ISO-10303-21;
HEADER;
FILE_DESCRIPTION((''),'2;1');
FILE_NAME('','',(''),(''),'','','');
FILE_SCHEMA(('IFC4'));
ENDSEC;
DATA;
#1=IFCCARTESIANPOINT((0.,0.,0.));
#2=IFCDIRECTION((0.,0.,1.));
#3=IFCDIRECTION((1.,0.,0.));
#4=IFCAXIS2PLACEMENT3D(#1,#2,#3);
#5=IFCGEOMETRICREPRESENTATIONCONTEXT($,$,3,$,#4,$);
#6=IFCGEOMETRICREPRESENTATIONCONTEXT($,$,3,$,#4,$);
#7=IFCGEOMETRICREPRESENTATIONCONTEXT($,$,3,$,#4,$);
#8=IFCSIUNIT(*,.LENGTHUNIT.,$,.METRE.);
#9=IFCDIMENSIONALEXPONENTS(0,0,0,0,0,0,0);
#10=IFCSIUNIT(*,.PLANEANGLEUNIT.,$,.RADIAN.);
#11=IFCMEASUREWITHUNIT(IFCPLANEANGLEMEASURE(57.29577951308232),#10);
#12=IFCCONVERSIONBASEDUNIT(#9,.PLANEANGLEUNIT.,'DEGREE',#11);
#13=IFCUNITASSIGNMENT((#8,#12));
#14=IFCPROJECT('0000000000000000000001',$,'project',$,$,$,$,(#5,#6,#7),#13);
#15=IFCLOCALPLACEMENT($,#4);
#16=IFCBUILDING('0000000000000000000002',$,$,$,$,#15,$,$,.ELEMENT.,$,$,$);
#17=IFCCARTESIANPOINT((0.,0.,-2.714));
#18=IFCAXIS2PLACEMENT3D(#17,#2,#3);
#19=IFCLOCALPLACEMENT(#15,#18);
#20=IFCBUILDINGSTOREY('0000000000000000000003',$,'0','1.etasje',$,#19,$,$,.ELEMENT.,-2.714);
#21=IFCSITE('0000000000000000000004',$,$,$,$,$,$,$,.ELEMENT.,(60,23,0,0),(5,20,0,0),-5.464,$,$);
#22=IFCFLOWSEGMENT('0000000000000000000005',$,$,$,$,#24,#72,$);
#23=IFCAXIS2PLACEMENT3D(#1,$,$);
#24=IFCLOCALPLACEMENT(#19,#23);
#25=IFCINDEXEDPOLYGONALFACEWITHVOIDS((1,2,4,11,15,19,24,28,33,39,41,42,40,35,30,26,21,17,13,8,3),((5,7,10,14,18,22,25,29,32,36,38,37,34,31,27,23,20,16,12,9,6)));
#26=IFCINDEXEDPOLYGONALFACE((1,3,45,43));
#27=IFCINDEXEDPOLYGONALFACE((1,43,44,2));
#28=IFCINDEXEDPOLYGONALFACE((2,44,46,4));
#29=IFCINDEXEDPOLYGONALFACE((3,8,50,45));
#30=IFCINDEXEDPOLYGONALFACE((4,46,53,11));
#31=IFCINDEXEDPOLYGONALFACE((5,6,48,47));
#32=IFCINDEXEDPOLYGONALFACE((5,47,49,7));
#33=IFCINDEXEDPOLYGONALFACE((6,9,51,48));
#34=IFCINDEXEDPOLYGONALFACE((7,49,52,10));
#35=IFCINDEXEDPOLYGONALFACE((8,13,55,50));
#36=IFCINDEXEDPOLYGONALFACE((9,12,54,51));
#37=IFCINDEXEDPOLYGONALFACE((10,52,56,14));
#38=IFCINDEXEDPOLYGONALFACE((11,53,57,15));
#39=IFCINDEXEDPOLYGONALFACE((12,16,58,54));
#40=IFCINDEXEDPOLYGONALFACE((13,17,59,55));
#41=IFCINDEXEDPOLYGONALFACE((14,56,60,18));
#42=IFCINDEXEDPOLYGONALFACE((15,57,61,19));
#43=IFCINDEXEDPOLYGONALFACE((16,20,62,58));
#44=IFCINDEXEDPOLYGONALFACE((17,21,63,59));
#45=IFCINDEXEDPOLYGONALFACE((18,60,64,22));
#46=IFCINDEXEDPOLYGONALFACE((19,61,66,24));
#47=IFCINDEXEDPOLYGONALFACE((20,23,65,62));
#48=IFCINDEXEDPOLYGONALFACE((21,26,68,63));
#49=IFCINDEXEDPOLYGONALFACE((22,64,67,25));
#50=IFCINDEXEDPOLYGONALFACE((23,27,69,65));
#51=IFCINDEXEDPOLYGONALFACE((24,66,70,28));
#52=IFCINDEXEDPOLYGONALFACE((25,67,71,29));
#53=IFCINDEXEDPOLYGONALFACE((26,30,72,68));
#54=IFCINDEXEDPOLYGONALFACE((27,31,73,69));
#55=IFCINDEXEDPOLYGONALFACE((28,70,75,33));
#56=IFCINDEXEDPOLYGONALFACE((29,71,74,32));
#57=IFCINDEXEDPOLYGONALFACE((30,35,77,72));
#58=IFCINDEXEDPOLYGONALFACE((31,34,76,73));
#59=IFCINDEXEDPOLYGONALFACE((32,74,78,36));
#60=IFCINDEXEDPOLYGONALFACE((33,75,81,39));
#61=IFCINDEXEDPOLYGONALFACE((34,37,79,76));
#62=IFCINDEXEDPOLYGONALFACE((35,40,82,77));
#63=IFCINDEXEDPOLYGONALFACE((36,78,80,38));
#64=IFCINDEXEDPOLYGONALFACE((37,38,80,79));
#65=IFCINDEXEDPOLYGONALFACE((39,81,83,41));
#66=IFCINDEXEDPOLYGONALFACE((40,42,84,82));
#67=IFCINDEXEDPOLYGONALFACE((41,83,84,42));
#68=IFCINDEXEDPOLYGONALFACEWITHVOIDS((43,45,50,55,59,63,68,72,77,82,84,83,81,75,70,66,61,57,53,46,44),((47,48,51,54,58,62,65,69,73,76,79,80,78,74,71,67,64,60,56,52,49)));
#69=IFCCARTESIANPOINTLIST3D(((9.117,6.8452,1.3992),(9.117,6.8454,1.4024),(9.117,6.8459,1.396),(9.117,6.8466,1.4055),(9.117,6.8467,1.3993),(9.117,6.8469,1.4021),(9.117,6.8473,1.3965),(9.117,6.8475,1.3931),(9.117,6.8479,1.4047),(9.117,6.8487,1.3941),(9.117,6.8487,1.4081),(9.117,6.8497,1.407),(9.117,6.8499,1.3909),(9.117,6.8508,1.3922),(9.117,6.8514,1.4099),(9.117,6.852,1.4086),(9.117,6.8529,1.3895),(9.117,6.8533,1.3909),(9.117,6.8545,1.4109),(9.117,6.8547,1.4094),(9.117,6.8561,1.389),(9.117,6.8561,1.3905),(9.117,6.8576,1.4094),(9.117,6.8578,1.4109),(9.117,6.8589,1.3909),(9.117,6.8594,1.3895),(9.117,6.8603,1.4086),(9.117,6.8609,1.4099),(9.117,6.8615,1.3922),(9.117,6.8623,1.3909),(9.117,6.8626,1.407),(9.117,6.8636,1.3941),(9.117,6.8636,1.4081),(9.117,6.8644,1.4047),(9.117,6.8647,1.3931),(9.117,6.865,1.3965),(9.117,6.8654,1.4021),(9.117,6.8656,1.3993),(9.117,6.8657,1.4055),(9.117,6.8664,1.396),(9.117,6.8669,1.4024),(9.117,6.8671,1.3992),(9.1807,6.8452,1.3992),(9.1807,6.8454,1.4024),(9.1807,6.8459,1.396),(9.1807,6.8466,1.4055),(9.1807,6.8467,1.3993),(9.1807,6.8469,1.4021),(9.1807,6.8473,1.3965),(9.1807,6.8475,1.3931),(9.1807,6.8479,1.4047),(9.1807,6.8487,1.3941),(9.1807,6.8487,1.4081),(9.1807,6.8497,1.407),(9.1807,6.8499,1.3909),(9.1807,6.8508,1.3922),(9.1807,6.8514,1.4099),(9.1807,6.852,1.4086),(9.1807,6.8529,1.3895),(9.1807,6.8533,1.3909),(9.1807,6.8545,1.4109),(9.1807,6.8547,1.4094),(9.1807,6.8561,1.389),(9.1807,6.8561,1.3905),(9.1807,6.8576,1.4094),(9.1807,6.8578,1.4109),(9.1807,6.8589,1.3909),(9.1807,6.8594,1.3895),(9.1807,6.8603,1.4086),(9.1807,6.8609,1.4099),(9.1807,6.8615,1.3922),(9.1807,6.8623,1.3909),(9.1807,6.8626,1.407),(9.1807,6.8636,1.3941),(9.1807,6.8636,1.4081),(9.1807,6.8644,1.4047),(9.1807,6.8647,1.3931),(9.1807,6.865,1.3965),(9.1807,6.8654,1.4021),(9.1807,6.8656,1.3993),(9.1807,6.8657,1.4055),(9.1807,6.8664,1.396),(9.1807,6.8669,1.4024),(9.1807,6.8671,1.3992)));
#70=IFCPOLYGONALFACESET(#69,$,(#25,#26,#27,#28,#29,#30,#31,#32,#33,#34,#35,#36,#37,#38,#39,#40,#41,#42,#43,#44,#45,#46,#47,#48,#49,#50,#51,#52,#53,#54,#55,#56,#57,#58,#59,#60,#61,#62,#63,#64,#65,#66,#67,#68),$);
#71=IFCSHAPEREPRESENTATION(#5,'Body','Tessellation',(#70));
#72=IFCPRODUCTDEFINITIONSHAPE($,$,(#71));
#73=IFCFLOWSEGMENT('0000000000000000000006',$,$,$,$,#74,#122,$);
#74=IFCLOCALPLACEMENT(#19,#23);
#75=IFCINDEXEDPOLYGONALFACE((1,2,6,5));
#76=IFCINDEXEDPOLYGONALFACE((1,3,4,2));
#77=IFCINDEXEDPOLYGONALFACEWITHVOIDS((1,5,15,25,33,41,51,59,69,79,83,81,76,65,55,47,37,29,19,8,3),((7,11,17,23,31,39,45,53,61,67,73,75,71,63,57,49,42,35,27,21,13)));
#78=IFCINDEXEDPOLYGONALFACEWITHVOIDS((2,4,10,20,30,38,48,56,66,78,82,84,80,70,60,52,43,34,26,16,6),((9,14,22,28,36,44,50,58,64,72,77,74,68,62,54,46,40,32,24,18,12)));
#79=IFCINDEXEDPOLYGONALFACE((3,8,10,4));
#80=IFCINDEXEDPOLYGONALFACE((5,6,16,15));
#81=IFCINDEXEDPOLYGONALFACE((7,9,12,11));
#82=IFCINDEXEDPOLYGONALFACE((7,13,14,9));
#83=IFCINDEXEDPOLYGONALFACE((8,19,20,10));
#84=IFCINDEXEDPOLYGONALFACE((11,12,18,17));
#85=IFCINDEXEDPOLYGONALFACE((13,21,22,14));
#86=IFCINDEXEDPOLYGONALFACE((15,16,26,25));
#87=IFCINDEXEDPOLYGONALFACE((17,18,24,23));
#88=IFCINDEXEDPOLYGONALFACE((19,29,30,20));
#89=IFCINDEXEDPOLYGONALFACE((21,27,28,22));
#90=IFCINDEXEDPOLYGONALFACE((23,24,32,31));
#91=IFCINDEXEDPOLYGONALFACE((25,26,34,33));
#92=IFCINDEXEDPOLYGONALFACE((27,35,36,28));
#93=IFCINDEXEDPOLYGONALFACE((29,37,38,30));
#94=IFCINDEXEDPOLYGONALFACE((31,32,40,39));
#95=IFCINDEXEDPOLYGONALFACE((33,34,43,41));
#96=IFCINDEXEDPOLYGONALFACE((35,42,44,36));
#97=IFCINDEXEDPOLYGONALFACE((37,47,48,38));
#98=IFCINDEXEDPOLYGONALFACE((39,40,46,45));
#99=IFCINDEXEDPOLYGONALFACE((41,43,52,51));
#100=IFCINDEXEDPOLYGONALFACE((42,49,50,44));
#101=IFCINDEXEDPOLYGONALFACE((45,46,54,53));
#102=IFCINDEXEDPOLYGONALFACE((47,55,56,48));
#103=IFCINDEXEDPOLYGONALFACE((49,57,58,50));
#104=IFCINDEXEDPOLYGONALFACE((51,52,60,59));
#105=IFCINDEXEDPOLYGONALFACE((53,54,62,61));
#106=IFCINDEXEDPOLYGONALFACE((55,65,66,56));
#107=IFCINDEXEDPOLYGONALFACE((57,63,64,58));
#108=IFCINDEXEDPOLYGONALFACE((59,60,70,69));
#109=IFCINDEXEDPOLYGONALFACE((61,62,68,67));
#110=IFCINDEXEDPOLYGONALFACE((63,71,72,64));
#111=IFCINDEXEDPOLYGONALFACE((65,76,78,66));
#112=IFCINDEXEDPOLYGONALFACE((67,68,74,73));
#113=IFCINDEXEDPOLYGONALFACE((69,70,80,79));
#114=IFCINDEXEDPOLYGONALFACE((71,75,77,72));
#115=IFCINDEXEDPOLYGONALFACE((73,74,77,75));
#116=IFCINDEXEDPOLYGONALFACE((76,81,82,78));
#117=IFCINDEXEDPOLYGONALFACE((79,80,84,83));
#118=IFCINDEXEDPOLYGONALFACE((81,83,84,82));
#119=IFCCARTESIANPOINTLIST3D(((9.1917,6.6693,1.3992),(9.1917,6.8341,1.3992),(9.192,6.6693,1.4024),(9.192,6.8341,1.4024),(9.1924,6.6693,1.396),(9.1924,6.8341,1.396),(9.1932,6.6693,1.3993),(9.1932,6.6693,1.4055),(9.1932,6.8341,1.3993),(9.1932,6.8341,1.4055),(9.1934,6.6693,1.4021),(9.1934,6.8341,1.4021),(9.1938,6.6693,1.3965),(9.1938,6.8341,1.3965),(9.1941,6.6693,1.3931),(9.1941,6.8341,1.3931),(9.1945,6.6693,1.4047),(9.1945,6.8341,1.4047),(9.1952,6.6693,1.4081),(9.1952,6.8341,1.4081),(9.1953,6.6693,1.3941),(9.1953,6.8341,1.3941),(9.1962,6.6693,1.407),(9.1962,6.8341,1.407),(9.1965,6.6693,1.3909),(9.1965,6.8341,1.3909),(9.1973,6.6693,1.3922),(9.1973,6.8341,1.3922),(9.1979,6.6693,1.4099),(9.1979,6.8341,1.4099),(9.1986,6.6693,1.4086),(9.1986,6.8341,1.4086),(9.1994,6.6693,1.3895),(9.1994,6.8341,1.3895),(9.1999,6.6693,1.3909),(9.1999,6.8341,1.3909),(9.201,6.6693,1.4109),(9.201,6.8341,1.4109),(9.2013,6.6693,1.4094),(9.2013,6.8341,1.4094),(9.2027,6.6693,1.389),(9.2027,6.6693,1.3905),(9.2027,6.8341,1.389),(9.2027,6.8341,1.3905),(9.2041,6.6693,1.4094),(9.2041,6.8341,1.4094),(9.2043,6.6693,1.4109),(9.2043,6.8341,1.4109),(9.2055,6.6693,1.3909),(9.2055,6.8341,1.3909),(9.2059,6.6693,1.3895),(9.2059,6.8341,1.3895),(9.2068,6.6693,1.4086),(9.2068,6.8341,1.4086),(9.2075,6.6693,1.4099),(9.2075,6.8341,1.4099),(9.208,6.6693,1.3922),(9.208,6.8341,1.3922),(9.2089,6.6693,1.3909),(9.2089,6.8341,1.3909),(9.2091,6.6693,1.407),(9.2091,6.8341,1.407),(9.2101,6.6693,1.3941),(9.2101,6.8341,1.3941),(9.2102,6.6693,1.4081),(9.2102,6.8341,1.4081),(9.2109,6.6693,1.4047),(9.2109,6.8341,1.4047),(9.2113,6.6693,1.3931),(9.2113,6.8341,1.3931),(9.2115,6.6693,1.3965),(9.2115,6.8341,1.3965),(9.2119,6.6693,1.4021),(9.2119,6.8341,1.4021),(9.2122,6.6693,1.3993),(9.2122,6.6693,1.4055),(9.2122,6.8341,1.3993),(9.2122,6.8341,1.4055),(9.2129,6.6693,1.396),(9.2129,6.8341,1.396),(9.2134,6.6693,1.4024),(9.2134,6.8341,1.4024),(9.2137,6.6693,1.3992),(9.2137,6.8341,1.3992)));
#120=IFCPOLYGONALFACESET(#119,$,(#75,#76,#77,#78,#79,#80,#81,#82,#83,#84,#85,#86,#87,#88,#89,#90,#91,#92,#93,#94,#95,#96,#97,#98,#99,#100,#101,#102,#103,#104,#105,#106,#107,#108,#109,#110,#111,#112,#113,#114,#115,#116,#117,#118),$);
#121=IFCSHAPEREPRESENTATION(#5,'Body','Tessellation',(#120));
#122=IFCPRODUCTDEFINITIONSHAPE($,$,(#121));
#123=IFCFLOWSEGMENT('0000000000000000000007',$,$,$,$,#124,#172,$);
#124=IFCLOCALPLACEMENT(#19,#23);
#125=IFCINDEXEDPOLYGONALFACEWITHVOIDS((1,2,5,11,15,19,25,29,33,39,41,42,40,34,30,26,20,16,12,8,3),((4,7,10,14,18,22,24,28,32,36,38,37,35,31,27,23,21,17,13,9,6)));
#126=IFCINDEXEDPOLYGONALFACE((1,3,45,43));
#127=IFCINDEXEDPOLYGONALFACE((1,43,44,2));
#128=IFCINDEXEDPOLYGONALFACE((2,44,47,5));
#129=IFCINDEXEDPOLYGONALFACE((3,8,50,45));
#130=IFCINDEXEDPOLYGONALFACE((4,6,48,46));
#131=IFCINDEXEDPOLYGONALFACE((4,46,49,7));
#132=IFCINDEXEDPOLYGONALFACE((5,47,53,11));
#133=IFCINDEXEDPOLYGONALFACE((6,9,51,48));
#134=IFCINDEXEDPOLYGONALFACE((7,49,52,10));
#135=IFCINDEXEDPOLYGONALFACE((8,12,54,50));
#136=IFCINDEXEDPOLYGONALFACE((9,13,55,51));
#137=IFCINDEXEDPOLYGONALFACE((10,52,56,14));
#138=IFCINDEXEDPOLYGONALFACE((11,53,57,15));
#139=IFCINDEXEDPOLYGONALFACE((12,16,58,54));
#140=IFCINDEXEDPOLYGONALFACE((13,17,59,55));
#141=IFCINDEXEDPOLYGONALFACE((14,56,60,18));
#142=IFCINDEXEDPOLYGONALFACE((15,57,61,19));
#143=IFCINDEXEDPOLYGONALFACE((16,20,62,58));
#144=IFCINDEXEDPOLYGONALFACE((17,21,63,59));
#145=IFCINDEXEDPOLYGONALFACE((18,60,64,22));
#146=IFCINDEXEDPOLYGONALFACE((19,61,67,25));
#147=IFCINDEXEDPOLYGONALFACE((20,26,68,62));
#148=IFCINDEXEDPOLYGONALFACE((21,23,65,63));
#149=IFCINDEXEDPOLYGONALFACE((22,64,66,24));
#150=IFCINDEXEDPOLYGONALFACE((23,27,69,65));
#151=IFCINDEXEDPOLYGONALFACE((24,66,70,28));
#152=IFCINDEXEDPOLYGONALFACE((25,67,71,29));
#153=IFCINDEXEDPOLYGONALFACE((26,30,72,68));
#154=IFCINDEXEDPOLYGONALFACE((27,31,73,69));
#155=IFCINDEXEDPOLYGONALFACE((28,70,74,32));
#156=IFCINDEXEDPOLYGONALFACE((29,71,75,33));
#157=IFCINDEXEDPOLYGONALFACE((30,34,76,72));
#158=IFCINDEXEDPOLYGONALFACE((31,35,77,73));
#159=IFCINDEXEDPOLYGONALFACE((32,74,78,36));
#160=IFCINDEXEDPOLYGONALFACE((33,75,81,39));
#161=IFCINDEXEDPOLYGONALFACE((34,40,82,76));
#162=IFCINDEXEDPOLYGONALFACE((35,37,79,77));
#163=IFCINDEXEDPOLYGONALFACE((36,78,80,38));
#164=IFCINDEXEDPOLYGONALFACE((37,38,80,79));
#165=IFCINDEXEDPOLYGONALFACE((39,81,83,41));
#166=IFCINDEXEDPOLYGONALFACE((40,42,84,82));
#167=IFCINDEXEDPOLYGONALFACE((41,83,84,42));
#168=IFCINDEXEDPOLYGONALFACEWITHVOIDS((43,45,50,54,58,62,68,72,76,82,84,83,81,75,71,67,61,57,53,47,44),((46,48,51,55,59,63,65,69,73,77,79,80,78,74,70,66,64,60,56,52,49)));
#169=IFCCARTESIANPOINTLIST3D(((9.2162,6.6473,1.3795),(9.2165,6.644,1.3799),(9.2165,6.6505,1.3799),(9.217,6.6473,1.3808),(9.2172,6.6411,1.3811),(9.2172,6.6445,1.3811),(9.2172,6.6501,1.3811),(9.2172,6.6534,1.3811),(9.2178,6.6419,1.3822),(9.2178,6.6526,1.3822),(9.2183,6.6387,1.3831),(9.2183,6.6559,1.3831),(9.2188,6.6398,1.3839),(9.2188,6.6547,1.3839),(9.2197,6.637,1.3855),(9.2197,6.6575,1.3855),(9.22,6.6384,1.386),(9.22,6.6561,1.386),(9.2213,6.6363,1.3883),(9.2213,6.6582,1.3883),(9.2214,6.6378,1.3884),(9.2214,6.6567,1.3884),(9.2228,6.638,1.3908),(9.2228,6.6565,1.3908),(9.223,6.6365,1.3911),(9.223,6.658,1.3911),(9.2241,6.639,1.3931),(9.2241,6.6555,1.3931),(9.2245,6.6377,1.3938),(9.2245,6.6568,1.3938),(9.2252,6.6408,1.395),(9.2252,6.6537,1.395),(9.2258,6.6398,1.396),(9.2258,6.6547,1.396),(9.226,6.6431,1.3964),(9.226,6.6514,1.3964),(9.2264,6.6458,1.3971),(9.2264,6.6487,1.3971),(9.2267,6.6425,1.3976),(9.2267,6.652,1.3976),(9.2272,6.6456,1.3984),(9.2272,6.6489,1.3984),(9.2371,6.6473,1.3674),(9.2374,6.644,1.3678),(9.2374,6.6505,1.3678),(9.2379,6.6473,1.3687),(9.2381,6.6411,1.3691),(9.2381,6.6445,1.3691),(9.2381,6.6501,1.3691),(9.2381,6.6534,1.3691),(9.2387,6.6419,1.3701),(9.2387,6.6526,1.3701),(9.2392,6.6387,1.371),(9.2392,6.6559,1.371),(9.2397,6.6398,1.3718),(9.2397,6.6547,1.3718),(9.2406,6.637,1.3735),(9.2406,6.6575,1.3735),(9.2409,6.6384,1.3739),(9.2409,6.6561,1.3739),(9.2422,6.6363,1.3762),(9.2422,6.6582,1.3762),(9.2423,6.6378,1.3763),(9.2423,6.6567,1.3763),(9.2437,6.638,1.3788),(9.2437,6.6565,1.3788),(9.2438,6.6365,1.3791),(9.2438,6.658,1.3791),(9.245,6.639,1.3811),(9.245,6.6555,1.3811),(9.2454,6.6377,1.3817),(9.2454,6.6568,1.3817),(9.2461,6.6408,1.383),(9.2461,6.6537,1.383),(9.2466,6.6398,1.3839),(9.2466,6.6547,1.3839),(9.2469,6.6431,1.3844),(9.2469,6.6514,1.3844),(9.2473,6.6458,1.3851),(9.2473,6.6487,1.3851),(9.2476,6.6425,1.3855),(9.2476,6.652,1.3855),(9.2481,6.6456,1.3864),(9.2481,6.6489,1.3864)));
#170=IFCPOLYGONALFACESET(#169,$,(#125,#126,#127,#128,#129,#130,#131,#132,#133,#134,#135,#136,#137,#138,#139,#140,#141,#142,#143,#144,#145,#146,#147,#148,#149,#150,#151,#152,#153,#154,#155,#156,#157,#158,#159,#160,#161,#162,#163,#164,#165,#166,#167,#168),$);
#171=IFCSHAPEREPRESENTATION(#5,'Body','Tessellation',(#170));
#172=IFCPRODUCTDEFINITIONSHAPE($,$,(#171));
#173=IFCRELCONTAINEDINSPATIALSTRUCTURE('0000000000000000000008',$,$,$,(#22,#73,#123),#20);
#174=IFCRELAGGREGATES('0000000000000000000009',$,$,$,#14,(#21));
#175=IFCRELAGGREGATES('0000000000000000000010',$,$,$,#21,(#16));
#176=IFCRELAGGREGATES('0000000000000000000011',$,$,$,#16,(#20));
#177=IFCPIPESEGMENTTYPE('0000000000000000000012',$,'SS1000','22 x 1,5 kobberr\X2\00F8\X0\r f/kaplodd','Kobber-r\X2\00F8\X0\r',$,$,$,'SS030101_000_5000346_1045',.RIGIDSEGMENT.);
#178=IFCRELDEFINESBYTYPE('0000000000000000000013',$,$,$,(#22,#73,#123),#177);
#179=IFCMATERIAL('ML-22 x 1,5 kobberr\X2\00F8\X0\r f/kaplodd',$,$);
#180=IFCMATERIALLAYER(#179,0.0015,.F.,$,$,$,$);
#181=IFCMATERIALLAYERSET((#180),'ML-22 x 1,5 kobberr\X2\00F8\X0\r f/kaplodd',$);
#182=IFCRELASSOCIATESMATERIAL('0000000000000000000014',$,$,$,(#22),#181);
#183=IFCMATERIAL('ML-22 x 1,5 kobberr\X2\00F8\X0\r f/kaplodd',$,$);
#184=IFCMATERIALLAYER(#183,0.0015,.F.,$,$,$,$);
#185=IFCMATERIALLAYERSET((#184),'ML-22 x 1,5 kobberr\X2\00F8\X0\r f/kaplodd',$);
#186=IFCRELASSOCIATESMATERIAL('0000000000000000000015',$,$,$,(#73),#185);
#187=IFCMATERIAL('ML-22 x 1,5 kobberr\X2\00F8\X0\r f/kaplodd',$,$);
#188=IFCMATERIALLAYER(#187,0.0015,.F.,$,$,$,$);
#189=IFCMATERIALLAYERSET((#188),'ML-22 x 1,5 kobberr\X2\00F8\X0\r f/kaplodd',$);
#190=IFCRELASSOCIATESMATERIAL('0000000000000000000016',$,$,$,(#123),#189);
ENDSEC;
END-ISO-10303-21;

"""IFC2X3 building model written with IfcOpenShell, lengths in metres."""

from ifc_helpers import new_model, entity, si_unit, converted_unit, frame, origin_with_axes, origin_2d_with_axis, place, context, project, spatial, hollow_circle, extrude, material, layer, layer_set, layer_usage, type_object, element, save


model = new_model("IFC2X3")

# Units and contexts
context_of_model_1 = context(None, 3, world=origin_with_axes())
context_of_model_2 = context(None, 3, world=origin_with_axes())
context_of_model_3 = context(None, 3, world=origin_with_axes())
ifc_project = project(units=[si_unit("LENGTHUNIT", "METRE"), converted_unit("PLANEANGLEUNIT", "DEGREE", entity("IfcPlaneAngleMeasure", 57.29577951308232), si_unit("PLANEANGLEUNIT", "RADIAN"), dimensions=[0, 0, 0, 0, 0, 0, 0])], contexts=[context_of_model_1, context_of_model_2, context_of_model_3])

# Site, building, storey
site = spatial("IfcSite", under=ifc_project, CompositionType="ELEMENT", RefLatitude=(60, 23, 0, 0), RefLongitude=(5, 20, 0, 0), RefElevation=-5.464)
building_placement = place(None, origin_with_axes())
building = spatial("IfcBuilding", under=site, at=building_placement, CompositionType="ELEMENT")
storey_placement = place(building_placement, frame((0.0, 0.0, -2.714), z_axis=(0.0, 0.0, 1.0), x_axis=(1.0, 0.0, 0.0)))
storey = spatial("IfcBuildingStorey", under=building, at=storey_placement, Name="0", Description="1.etasje", CompositionType="ELEMENT", Elevation=-2.714)

# Flow segments
pipe_segment_type_1 = type_object("IfcPipeSegmentType", Name="SS1000", Description="22 x 1,5 kobberrør f/kaplodd", ApplicableOccurrence="Kobber-rør", ElementType="SS030101_000_5000346_1045", PredefinedType="RIGIDSEGMENT")
ifc_material_1 = material(Name="ML-22 x 1,5 kobberrør f/kaplodd")
ifc_layer_1 = layer(ifc_material_1, 0.0015, ventilated=False)
ifc_layer_set_1 = layer_set([ifc_layer_1], Name="ML-22 x 1,5 kobberrør f/kaplodd")
ifc_layer_usage_1 = layer_usage(ifc_layer_set_1, "AXIS2", "POSITIVE", 0.0)
flow_segment_1_placement = place(storey_placement, frame((9.117, 6.8561, 1.4), z_axis=(1.0, 0.0, 0.0), x_axis=(0.0, 0.0, -1.0)))
element("IfcFlowSegment", 1, at=flow_segment_1_placement, inside=storey, type_object=pipe_segment_type_1, material=ifc_layer_usage_1, context=context_of_model_1, shape_type="SweptSolid", body=[
    extrude(hollow_circle(Radius=0.011, WallThickness=0.0015, at=origin_2d_with_axis()), origin_with_axes(), (0.0, 0.0, 1.0), 0.0637),
])
ifc_material_2 = material(Name="ML-22 x 1,5 kobberrør f/kaplodd")
ifc_layer_2 = layer(ifc_material_2, 0.0015, ventilated=False)
ifc_layer_set_2 = layer_set([ifc_layer_2], Name="ML-22 x 1,5 kobberrør f/kaplodd")
ifc_layer_usage_2 = layer_usage(ifc_layer_set_2, "AXIS2", "POSITIVE", 0.0)
flow_segment_2_placement = place(storey_placement, frame((9.2027, 6.8341, 1.4), z_axis=(0.0, -1.0, 0.0), x_axis=(0.0, 0.0, -1.0)))
element("IfcFlowSegment", 2, at=flow_segment_2_placement, inside=storey, type_object=pipe_segment_type_1, material=ifc_layer_usage_2, context=context_of_model_1, shape_type="SweptSolid", body=[
    extrude(hollow_circle(Radius=0.011, WallThickness=0.0015, at=origin_2d_with_axis()), origin_with_axes(), (0.0, 0.0, 1.0), 0.1649),
])
ifc_material_3 = material(Name="ML-22 x 1,5 kobberrør f/kaplodd")
ifc_layer_3 = layer(ifc_material_3, 0.0015, ventilated=False)
ifc_layer_set_3 = layer_set([ifc_layer_3], Name="ML-22 x 1,5 kobberrør f/kaplodd")
ifc_layer_usage_3 = layer_usage(ifc_layer_set_3, "AXIS2", "POSITIVE", 0.0)
flow_segment_3_placement = place(storey_placement, frame((9.2217, 6.6473, 1.389), z_axis=(0.866025, 0.0, -0.5), x_axis=(-0.5, 0.0, -0.866025)))
element("IfcFlowSegment", 3, at=flow_segment_3_placement, inside=storey, type_object=pipe_segment_type_1, material=ifc_layer_usage_3, context=context_of_model_1, shape_type="SweptSolid", body=[
    extrude(hollow_circle(Radius=0.011, WallThickness=0.0015, at=origin_2d_with_axis()), origin_with_axes(), (0.0, 0.0, 1.0), 0.0241),
])

save(model, "model.ifc")
